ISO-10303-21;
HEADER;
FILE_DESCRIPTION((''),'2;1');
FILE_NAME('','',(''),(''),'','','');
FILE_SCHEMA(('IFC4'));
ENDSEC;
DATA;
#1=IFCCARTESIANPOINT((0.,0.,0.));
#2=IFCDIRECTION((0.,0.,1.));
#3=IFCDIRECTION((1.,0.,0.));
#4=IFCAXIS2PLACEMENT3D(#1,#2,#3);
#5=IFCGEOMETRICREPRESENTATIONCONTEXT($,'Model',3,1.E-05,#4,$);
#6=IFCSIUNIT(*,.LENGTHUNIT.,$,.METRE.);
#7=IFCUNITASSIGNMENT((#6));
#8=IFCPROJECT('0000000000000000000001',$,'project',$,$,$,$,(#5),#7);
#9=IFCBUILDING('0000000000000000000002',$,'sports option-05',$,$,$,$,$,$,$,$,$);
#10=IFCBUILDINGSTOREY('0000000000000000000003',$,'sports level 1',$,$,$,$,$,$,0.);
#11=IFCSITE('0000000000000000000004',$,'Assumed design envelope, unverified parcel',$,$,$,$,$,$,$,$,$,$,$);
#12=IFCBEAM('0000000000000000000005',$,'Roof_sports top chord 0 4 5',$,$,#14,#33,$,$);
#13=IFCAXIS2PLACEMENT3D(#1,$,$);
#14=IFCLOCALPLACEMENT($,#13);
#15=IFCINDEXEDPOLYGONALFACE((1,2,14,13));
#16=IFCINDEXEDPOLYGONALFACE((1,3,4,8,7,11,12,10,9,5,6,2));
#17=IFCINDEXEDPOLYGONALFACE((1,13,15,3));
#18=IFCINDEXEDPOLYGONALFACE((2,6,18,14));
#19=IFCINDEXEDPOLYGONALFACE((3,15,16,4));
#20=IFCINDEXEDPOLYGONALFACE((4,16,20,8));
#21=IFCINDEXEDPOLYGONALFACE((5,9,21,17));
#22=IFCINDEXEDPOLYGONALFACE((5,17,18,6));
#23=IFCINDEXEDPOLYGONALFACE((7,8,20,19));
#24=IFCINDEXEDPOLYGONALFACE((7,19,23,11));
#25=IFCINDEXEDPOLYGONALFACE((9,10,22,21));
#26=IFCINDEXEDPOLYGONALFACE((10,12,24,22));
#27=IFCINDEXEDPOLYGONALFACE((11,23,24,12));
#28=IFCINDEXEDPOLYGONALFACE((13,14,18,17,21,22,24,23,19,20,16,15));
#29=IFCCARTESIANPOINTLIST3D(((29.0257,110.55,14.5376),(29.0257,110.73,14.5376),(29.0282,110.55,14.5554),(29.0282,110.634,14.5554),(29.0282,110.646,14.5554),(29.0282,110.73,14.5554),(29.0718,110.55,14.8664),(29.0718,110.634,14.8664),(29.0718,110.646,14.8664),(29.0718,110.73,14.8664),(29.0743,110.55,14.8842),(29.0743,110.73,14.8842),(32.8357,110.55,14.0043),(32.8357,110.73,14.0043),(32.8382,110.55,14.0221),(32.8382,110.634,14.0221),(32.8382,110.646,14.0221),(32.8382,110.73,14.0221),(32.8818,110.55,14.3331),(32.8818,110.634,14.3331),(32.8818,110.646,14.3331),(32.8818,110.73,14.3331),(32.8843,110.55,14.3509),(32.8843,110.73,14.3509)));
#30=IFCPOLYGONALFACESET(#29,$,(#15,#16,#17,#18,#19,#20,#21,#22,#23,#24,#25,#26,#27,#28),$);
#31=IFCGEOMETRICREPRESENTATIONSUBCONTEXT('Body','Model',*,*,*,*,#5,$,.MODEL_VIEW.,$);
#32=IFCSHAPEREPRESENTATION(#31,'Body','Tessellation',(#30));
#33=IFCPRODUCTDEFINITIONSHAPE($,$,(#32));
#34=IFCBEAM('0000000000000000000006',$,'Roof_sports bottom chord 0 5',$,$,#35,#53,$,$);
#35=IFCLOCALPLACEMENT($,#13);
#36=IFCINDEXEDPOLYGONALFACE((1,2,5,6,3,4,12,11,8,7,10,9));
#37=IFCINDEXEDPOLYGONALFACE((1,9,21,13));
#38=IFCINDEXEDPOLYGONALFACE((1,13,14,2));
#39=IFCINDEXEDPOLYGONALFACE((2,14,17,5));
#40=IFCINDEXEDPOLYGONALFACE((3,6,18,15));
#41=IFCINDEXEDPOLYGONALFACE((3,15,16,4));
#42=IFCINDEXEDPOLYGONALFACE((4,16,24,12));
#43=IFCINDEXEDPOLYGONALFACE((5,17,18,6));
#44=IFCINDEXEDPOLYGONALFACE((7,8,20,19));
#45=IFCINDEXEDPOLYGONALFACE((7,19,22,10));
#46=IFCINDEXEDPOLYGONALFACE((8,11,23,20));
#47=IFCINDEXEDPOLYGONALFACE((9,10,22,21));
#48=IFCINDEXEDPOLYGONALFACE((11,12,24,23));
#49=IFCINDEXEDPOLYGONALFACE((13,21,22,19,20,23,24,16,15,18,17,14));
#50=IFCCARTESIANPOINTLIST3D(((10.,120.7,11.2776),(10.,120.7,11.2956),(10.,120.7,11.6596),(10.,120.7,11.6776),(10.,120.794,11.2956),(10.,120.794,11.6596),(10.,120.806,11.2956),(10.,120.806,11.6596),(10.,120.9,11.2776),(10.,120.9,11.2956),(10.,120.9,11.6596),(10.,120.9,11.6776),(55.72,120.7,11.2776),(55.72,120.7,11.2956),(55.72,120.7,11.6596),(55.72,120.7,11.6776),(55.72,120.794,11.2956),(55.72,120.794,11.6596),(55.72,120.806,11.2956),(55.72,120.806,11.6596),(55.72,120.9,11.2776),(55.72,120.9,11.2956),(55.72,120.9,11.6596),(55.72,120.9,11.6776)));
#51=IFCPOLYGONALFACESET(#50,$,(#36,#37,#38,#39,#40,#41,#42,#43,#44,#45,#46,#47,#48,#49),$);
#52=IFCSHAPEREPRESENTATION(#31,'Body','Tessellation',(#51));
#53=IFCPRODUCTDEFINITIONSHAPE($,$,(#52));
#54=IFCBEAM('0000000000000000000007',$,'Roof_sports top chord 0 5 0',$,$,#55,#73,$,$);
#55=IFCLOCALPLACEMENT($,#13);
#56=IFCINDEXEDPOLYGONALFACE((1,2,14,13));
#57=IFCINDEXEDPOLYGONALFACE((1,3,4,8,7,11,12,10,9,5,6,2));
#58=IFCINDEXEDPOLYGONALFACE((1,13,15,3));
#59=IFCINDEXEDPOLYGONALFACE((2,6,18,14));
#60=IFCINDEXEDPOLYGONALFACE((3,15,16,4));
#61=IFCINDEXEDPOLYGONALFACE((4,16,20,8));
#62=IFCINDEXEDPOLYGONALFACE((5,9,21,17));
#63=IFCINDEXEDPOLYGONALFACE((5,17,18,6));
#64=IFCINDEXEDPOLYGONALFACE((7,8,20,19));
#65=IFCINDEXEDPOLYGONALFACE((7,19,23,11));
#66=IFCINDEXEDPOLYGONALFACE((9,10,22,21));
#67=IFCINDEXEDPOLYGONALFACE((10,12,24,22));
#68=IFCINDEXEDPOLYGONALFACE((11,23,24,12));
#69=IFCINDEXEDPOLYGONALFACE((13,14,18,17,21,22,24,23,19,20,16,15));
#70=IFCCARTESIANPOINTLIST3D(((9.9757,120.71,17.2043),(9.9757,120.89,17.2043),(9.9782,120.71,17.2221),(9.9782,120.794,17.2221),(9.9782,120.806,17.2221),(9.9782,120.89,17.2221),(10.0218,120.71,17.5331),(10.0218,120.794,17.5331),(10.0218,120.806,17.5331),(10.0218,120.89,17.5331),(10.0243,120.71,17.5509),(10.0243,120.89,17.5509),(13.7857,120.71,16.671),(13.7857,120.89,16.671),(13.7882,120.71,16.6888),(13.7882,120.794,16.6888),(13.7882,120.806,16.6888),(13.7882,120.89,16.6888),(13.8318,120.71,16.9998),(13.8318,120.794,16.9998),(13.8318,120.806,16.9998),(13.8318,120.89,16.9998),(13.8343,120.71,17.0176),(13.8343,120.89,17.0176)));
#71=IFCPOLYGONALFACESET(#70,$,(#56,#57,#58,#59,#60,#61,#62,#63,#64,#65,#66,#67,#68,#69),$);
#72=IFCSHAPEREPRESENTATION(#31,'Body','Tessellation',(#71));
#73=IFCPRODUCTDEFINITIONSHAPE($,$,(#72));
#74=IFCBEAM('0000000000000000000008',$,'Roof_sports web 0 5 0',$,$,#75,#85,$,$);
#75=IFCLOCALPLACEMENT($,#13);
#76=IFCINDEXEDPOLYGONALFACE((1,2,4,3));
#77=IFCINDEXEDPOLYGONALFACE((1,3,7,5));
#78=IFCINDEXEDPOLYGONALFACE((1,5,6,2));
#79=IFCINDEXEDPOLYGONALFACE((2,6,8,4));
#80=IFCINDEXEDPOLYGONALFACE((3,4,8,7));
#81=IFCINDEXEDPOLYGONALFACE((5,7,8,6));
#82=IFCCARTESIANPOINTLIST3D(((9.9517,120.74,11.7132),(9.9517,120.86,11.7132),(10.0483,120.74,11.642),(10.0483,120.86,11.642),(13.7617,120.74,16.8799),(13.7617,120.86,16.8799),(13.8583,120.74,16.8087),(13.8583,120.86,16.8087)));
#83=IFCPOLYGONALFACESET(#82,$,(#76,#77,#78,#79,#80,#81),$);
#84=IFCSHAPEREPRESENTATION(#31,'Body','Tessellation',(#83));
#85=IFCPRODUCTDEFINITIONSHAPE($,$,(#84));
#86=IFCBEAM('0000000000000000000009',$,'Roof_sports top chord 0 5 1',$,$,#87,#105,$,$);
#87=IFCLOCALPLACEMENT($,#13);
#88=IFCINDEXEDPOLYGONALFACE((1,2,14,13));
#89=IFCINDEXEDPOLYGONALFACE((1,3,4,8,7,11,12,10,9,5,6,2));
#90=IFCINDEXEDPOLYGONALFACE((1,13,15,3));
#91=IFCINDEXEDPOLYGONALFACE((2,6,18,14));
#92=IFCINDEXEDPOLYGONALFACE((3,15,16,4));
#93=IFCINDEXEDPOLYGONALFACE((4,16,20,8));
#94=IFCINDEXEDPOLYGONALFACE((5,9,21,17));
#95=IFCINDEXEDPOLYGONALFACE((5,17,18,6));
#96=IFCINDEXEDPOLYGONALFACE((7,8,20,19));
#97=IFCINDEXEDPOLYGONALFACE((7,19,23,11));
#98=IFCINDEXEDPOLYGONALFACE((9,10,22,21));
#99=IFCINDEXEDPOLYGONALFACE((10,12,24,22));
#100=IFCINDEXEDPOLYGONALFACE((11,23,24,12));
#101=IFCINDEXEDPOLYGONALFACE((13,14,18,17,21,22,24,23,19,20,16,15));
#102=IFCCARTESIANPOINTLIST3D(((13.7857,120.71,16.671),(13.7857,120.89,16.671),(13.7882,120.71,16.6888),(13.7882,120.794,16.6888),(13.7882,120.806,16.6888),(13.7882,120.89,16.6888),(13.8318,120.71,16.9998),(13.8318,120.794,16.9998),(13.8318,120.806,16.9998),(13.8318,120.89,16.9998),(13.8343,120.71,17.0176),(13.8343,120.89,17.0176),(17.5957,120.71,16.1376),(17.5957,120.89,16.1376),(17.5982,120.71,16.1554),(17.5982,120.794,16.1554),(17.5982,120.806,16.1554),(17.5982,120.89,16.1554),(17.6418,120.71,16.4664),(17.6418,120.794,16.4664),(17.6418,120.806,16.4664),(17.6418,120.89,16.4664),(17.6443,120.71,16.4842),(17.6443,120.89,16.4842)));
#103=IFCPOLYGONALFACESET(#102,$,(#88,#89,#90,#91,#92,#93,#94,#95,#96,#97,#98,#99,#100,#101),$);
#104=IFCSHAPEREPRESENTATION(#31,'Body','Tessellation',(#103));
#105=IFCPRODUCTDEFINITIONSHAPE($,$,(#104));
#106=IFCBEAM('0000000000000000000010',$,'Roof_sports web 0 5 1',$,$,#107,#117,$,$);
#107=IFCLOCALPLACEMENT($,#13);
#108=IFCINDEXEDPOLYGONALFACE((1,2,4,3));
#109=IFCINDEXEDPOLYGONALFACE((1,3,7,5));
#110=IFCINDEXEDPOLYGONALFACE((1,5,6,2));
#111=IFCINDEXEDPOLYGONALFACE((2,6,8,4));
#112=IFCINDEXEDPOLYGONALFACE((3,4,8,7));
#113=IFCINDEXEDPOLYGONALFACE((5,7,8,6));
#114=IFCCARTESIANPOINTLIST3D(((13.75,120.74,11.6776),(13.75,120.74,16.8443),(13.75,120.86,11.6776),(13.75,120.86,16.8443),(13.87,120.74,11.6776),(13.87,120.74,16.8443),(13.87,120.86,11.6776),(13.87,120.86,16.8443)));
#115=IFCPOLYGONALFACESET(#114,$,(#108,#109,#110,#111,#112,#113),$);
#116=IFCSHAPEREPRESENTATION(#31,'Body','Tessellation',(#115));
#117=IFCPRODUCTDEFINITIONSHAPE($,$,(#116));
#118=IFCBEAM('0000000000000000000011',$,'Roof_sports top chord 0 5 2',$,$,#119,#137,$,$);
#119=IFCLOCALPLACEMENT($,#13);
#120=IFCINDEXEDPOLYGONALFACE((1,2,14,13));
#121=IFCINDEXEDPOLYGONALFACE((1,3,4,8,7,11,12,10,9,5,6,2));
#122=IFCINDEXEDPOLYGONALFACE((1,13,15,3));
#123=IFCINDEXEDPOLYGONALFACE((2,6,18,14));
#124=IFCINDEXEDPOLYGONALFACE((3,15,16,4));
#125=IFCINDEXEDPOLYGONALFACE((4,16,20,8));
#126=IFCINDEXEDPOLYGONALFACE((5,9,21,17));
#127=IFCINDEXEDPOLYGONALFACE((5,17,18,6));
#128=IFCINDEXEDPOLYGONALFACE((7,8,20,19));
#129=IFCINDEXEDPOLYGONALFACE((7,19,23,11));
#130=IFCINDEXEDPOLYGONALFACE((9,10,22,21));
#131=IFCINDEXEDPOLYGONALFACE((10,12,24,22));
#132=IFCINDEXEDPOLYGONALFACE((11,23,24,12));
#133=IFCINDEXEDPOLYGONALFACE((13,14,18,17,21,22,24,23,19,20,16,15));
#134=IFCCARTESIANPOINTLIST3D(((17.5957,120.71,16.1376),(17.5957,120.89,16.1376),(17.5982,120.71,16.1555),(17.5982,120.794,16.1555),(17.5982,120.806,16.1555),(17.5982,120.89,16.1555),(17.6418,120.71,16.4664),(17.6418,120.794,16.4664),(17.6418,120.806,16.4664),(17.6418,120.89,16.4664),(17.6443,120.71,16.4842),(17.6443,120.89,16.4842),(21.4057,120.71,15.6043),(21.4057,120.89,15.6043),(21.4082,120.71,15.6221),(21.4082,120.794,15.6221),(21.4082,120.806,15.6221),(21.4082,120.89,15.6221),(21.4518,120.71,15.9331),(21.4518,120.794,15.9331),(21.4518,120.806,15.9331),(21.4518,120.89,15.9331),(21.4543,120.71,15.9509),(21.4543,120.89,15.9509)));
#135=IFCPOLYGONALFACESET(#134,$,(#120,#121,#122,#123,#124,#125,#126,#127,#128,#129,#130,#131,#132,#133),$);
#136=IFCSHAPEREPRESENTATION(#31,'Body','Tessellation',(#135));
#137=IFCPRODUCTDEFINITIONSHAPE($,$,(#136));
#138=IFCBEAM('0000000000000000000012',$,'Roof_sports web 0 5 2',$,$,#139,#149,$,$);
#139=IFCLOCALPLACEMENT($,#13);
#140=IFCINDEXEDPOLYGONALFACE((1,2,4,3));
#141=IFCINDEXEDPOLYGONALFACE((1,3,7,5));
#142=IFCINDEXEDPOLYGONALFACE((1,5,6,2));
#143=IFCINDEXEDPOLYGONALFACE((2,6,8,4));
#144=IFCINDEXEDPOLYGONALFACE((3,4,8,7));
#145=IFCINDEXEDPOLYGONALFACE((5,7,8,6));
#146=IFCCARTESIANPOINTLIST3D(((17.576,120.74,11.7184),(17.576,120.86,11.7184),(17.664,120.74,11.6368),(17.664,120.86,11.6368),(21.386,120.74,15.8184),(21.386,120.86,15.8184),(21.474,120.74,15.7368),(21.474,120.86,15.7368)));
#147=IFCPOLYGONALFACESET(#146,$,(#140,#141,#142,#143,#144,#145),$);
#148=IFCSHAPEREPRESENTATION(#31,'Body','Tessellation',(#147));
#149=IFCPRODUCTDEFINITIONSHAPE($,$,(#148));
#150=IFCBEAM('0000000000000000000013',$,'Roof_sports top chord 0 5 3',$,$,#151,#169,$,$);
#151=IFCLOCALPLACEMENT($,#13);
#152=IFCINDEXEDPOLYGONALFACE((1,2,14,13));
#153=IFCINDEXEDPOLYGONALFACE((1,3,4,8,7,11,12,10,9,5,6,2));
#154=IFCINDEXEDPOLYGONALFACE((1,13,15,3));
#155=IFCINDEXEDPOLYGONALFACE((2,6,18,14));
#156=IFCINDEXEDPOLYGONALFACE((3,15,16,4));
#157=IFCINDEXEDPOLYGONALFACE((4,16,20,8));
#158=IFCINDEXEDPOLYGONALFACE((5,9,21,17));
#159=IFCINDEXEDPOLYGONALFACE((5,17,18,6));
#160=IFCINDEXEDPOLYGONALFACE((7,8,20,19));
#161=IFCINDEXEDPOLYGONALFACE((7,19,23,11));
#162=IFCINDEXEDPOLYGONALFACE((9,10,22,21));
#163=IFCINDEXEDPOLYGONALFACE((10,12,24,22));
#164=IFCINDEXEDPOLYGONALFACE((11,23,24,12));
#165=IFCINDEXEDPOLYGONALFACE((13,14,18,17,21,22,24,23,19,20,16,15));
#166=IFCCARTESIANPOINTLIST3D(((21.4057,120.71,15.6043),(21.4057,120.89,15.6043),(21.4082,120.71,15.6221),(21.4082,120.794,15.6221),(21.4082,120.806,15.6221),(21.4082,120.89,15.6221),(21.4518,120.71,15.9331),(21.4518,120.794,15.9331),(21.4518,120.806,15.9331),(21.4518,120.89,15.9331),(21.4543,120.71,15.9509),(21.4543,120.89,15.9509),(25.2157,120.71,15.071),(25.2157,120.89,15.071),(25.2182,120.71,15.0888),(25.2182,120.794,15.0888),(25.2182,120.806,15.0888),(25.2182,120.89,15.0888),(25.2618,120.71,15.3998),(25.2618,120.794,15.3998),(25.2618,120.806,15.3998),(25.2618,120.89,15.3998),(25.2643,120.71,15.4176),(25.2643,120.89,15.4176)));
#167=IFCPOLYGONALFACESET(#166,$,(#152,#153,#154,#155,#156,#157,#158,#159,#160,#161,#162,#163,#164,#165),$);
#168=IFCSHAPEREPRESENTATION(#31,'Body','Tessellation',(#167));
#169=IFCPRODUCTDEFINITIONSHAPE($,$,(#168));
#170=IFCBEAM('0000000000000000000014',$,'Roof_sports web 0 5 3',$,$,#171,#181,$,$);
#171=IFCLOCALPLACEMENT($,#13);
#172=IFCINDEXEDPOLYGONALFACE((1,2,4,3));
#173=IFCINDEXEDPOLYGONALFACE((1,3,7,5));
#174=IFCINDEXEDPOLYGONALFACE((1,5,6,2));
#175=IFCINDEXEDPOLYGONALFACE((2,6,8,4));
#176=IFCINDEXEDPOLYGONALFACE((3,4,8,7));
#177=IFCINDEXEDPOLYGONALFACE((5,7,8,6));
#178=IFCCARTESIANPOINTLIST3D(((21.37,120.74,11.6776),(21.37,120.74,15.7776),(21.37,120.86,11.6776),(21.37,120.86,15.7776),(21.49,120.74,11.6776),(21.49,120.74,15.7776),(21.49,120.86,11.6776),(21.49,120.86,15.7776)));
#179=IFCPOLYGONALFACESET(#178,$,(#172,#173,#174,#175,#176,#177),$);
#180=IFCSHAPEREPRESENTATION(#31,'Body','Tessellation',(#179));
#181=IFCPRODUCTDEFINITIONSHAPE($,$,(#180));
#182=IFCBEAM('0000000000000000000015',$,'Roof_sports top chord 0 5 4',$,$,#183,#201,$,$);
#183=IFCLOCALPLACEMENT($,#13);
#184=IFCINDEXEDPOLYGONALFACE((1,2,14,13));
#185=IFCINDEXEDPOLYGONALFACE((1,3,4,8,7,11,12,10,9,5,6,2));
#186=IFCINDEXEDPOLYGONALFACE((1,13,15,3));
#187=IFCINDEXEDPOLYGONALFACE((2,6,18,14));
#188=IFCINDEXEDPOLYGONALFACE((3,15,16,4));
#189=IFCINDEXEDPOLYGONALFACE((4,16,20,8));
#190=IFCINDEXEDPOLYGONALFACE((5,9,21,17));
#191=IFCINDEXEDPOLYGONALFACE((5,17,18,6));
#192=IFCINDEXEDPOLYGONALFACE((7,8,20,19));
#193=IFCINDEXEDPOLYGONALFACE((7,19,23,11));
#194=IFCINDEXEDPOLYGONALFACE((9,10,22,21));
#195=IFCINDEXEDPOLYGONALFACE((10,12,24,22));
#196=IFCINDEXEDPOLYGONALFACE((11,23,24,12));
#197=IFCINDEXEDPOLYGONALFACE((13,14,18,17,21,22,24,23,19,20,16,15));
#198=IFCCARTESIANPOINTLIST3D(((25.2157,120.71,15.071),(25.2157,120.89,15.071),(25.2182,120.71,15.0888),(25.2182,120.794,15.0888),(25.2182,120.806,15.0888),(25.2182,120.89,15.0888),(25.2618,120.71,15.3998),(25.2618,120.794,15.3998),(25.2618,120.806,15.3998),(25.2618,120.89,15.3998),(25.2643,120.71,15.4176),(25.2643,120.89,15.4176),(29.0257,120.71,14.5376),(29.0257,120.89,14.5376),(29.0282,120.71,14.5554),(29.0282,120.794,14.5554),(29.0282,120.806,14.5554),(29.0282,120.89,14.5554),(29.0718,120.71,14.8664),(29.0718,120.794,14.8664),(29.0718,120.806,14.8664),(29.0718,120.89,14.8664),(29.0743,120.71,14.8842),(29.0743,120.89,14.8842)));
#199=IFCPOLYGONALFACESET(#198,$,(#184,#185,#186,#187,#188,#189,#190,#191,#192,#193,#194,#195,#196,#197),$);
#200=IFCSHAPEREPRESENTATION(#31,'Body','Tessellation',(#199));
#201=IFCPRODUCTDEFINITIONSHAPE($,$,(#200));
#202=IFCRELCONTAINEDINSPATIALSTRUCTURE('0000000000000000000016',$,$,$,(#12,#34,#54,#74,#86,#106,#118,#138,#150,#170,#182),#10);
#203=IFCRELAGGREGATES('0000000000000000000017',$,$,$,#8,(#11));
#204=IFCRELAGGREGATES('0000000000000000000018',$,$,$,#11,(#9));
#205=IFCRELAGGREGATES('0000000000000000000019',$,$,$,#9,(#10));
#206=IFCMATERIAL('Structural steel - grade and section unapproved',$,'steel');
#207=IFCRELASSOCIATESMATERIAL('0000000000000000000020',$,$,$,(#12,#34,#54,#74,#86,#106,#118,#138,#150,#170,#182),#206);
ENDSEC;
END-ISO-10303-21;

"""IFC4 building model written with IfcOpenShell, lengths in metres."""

from ifc_helpers import new_model, si_unit, frame, origin_with_axes, place, context, subcontext, project, spatial, rectangle, i_section, extrude, material, element, save


model = new_model("IFC4")

# Units and contexts
model_context = context("Model", 3, precision=1e-05, world=origin_with_axes())
body_context = subcontext(model_context, "Body", "Model", "MODEL_VIEW")
ifc_project = project(units=[si_unit("LENGTHUNIT", "METRE")], contexts=[model_context])

# Site, building, storey
site = spatial("IfcSite", under=ifc_project, Name="Assumed design envelope, unverified parcel")
building = spatial("IfcBuilding", under=site, Name="sports option-05")
storey = spatial("IfcBuildingStorey", under=building, Name="sports level 1", Elevation=0.0)

# Shared definitions
ifc_material_1 = material(Name="Structural steel - grade and section unapproved", Category="steel")

# Beams
beam_1_placement = place(None, frame((29.05, 110.64, 14.7109), z_axis=(0.990344, 0.0, -0.138631), x_axis=(0.0, 1.0, 0.0)))
element("IfcBeam", 1, at=beam_1_placement, inside=storey, material=ifc_material_1, Name="Roof_sports top chord 0 4 5", context=body_context, shape_type="SweptSolid", body=[
    extrude(i_section(OverallWidth=0.18, OverallDepth=0.35, WebThickness=0.012, FlangeThickness=0.018, FilletRadius=0.0), origin_with_axes(), (0.0, 0.0, 1.0), 3.8471),
])
beam_2_placement = place(None, frame((10.0, 120.8, 11.4776), z_axis=(1.0, 0.0, 0.0), x_axis=(0.0, 1.0, 0.0)))
element("IfcBeam", 2, at=beam_2_placement, inside=storey, material=ifc_material_1, Name="Roof_sports bottom chord 0 5", context=body_context, shape_type="SweptSolid", body=[
    extrude(i_section(OverallWidth=0.2, OverallDepth=0.4, WebThickness=0.012, FlangeThickness=0.018, FilletRadius=0.0), origin_with_axes(), (0.0, 0.0, 1.0), 45.72),
])
beam_3_placement = place(None, frame((10.0, 120.8, 17.3776), z_axis=(0.990344, 0.0, -0.138631), x_axis=(0.0, 1.0, 0.0)))
element("IfcBeam", 3, at=beam_3_placement, inside=storey, material=ifc_material_1, Name="Roof_sports top chord 0 5 0", context=body_context, shape_type="SweptSolid", body=[
    extrude(i_section(OverallWidth=0.18, OverallDepth=0.35, WebThickness=0.012, FlangeThickness=0.018, FilletRadius=0.0), origin_with_axes(), (0.0, 0.0, 1.0), 3.8471),
])
beam_4_placement = place(None, frame((10.0, 120.8, 11.6776), z_axis=(0.5935, 0.0, 0.804834), x_axis=(0.0, 1.0, 0.0)))
element("IfcBeam", 4, at=beam_4_placement, inside=storey, material=ifc_material_1, Name="Roof_sports web 0 5 0", context=body_context, shape_type="SweptSolid", body=[
    extrude(rectangle(XDim=0.12, YDim=0.12), origin_with_axes(), (0.0, 0.0, 1.0), 6.4195),
])
beam_5_placement = place(None, frame((13.81, 120.8, 16.8443), z_axis=(0.990344, 0.0, -0.138631), x_axis=(0.0, 1.0, 0.0)))
element("IfcBeam", 5, at=beam_5_placement, inside=storey, material=ifc_material_1, Name="Roof_sports top chord 0 5 1", context=body_context, shape_type="SweptSolid", body=[
    extrude(i_section(OverallWidth=0.18, OverallDepth=0.35, WebThickness=0.012, FlangeThickness=0.018, FilletRadius=0.0), origin_with_axes(), (0.0, 0.0, 1.0), 3.8471),
])
beam_6_placement = place(None, frame((13.81, 120.8, 11.6776), z_axis=(0.0, 0.0, 1.0), x_axis=(-1.0, 0.0, 0.0)))
element("IfcBeam", 6, at=beam_6_placement, inside=storey, material=ifc_material_1, Name="Roof_sports web 0 5 1", context=body_context, shape_type="SweptSolid", body=[
    extrude(rectangle(XDim=0.12, YDim=0.12), origin_with_axes(), (0.0, 0.0, 1.0), 5.1667),
])
beam_7_placement = place(None, frame((17.62, 120.8, 16.3109), z_axis=(0.990344, 0.0, -0.138631), x_axis=(0.0, 1.0, 0.0)))
element("IfcBeam", 7, at=beam_7_placement, inside=storey, material=ifc_material_1, Name="Roof_sports top chord 0 5 2", context=body_context, shape_type="SweptSolid", body=[
    extrude(i_section(OverallWidth=0.18, OverallDepth=0.35, WebThickness=0.012, FlangeThickness=0.018, FilletRadius=0.0), origin_with_axes(), (0.0, 0.0, 1.0), 3.8471),
])
beam_8_placement = place(None, frame((17.62, 120.8, 11.6776), z_axis=(0.680725, 0.0, 0.732539), x_axis=(0.0, 1.0, 0.0)))
element("IfcBeam", 8, at=beam_8_placement, inside=storey, material=ifc_material_1, Name="Roof_sports web 0 5 2", context=body_context, shape_type="SweptSolid", body=[
    extrude(rectangle(XDim=0.12, YDim=0.12), origin_with_axes(), (0.0, 0.0, 1.0), 5.597),
])
beam_9_placement = place(None, frame((21.43, 120.8, 15.7776), z_axis=(0.990344, 0.0, -0.138631), x_axis=(0.0, 1.0, 0.0)))
element("IfcBeam", 9, at=beam_9_placement, inside=storey, material=ifc_material_1, Name="Roof_sports top chord 0 5 3", context=body_context, shape_type="SweptSolid", body=[
    extrude(i_section(OverallWidth=0.18, OverallDepth=0.35, WebThickness=0.012, FlangeThickness=0.018, FilletRadius=0.0), origin_with_axes(), (0.0, 0.0, 1.0), 3.8471),
])
beam_10_placement = place(None, frame((21.43, 120.8, 11.6776), z_axis=(0.0, 0.0, 1.0), x_axis=(-1.0, 0.0, 0.0)))
element("IfcBeam", 10, at=beam_10_placement, inside=storey, material=ifc_material_1, Name="Roof_sports web 0 5 3", context=body_context, shape_type="SweptSolid", body=[
    extrude(rectangle(XDim=0.12, YDim=0.12), origin_with_axes(), (0.0, 0.0, 1.0), 4.1),
])
beam_11_placement = place(None, frame((25.24, 120.8, 15.2443), z_axis=(0.990344, 0.0, -0.138631), x_axis=(0.0, 1.0, 0.0)))
element("IfcBeam", 11, at=beam_11_placement, inside=storey, material=ifc_material_1, Name="Roof_sports top chord 0 5 4", context=body_context, shape_type="SweptSolid", body=[
    extrude(i_section(OverallWidth=0.18, OverallDepth=0.35, WebThickness=0.012, FlangeThickness=0.018, FilletRadius=0.0), origin_with_axes(), (0.0, 0.0, 1.0), 3.8471),
])

save(model, "model.ifc")
